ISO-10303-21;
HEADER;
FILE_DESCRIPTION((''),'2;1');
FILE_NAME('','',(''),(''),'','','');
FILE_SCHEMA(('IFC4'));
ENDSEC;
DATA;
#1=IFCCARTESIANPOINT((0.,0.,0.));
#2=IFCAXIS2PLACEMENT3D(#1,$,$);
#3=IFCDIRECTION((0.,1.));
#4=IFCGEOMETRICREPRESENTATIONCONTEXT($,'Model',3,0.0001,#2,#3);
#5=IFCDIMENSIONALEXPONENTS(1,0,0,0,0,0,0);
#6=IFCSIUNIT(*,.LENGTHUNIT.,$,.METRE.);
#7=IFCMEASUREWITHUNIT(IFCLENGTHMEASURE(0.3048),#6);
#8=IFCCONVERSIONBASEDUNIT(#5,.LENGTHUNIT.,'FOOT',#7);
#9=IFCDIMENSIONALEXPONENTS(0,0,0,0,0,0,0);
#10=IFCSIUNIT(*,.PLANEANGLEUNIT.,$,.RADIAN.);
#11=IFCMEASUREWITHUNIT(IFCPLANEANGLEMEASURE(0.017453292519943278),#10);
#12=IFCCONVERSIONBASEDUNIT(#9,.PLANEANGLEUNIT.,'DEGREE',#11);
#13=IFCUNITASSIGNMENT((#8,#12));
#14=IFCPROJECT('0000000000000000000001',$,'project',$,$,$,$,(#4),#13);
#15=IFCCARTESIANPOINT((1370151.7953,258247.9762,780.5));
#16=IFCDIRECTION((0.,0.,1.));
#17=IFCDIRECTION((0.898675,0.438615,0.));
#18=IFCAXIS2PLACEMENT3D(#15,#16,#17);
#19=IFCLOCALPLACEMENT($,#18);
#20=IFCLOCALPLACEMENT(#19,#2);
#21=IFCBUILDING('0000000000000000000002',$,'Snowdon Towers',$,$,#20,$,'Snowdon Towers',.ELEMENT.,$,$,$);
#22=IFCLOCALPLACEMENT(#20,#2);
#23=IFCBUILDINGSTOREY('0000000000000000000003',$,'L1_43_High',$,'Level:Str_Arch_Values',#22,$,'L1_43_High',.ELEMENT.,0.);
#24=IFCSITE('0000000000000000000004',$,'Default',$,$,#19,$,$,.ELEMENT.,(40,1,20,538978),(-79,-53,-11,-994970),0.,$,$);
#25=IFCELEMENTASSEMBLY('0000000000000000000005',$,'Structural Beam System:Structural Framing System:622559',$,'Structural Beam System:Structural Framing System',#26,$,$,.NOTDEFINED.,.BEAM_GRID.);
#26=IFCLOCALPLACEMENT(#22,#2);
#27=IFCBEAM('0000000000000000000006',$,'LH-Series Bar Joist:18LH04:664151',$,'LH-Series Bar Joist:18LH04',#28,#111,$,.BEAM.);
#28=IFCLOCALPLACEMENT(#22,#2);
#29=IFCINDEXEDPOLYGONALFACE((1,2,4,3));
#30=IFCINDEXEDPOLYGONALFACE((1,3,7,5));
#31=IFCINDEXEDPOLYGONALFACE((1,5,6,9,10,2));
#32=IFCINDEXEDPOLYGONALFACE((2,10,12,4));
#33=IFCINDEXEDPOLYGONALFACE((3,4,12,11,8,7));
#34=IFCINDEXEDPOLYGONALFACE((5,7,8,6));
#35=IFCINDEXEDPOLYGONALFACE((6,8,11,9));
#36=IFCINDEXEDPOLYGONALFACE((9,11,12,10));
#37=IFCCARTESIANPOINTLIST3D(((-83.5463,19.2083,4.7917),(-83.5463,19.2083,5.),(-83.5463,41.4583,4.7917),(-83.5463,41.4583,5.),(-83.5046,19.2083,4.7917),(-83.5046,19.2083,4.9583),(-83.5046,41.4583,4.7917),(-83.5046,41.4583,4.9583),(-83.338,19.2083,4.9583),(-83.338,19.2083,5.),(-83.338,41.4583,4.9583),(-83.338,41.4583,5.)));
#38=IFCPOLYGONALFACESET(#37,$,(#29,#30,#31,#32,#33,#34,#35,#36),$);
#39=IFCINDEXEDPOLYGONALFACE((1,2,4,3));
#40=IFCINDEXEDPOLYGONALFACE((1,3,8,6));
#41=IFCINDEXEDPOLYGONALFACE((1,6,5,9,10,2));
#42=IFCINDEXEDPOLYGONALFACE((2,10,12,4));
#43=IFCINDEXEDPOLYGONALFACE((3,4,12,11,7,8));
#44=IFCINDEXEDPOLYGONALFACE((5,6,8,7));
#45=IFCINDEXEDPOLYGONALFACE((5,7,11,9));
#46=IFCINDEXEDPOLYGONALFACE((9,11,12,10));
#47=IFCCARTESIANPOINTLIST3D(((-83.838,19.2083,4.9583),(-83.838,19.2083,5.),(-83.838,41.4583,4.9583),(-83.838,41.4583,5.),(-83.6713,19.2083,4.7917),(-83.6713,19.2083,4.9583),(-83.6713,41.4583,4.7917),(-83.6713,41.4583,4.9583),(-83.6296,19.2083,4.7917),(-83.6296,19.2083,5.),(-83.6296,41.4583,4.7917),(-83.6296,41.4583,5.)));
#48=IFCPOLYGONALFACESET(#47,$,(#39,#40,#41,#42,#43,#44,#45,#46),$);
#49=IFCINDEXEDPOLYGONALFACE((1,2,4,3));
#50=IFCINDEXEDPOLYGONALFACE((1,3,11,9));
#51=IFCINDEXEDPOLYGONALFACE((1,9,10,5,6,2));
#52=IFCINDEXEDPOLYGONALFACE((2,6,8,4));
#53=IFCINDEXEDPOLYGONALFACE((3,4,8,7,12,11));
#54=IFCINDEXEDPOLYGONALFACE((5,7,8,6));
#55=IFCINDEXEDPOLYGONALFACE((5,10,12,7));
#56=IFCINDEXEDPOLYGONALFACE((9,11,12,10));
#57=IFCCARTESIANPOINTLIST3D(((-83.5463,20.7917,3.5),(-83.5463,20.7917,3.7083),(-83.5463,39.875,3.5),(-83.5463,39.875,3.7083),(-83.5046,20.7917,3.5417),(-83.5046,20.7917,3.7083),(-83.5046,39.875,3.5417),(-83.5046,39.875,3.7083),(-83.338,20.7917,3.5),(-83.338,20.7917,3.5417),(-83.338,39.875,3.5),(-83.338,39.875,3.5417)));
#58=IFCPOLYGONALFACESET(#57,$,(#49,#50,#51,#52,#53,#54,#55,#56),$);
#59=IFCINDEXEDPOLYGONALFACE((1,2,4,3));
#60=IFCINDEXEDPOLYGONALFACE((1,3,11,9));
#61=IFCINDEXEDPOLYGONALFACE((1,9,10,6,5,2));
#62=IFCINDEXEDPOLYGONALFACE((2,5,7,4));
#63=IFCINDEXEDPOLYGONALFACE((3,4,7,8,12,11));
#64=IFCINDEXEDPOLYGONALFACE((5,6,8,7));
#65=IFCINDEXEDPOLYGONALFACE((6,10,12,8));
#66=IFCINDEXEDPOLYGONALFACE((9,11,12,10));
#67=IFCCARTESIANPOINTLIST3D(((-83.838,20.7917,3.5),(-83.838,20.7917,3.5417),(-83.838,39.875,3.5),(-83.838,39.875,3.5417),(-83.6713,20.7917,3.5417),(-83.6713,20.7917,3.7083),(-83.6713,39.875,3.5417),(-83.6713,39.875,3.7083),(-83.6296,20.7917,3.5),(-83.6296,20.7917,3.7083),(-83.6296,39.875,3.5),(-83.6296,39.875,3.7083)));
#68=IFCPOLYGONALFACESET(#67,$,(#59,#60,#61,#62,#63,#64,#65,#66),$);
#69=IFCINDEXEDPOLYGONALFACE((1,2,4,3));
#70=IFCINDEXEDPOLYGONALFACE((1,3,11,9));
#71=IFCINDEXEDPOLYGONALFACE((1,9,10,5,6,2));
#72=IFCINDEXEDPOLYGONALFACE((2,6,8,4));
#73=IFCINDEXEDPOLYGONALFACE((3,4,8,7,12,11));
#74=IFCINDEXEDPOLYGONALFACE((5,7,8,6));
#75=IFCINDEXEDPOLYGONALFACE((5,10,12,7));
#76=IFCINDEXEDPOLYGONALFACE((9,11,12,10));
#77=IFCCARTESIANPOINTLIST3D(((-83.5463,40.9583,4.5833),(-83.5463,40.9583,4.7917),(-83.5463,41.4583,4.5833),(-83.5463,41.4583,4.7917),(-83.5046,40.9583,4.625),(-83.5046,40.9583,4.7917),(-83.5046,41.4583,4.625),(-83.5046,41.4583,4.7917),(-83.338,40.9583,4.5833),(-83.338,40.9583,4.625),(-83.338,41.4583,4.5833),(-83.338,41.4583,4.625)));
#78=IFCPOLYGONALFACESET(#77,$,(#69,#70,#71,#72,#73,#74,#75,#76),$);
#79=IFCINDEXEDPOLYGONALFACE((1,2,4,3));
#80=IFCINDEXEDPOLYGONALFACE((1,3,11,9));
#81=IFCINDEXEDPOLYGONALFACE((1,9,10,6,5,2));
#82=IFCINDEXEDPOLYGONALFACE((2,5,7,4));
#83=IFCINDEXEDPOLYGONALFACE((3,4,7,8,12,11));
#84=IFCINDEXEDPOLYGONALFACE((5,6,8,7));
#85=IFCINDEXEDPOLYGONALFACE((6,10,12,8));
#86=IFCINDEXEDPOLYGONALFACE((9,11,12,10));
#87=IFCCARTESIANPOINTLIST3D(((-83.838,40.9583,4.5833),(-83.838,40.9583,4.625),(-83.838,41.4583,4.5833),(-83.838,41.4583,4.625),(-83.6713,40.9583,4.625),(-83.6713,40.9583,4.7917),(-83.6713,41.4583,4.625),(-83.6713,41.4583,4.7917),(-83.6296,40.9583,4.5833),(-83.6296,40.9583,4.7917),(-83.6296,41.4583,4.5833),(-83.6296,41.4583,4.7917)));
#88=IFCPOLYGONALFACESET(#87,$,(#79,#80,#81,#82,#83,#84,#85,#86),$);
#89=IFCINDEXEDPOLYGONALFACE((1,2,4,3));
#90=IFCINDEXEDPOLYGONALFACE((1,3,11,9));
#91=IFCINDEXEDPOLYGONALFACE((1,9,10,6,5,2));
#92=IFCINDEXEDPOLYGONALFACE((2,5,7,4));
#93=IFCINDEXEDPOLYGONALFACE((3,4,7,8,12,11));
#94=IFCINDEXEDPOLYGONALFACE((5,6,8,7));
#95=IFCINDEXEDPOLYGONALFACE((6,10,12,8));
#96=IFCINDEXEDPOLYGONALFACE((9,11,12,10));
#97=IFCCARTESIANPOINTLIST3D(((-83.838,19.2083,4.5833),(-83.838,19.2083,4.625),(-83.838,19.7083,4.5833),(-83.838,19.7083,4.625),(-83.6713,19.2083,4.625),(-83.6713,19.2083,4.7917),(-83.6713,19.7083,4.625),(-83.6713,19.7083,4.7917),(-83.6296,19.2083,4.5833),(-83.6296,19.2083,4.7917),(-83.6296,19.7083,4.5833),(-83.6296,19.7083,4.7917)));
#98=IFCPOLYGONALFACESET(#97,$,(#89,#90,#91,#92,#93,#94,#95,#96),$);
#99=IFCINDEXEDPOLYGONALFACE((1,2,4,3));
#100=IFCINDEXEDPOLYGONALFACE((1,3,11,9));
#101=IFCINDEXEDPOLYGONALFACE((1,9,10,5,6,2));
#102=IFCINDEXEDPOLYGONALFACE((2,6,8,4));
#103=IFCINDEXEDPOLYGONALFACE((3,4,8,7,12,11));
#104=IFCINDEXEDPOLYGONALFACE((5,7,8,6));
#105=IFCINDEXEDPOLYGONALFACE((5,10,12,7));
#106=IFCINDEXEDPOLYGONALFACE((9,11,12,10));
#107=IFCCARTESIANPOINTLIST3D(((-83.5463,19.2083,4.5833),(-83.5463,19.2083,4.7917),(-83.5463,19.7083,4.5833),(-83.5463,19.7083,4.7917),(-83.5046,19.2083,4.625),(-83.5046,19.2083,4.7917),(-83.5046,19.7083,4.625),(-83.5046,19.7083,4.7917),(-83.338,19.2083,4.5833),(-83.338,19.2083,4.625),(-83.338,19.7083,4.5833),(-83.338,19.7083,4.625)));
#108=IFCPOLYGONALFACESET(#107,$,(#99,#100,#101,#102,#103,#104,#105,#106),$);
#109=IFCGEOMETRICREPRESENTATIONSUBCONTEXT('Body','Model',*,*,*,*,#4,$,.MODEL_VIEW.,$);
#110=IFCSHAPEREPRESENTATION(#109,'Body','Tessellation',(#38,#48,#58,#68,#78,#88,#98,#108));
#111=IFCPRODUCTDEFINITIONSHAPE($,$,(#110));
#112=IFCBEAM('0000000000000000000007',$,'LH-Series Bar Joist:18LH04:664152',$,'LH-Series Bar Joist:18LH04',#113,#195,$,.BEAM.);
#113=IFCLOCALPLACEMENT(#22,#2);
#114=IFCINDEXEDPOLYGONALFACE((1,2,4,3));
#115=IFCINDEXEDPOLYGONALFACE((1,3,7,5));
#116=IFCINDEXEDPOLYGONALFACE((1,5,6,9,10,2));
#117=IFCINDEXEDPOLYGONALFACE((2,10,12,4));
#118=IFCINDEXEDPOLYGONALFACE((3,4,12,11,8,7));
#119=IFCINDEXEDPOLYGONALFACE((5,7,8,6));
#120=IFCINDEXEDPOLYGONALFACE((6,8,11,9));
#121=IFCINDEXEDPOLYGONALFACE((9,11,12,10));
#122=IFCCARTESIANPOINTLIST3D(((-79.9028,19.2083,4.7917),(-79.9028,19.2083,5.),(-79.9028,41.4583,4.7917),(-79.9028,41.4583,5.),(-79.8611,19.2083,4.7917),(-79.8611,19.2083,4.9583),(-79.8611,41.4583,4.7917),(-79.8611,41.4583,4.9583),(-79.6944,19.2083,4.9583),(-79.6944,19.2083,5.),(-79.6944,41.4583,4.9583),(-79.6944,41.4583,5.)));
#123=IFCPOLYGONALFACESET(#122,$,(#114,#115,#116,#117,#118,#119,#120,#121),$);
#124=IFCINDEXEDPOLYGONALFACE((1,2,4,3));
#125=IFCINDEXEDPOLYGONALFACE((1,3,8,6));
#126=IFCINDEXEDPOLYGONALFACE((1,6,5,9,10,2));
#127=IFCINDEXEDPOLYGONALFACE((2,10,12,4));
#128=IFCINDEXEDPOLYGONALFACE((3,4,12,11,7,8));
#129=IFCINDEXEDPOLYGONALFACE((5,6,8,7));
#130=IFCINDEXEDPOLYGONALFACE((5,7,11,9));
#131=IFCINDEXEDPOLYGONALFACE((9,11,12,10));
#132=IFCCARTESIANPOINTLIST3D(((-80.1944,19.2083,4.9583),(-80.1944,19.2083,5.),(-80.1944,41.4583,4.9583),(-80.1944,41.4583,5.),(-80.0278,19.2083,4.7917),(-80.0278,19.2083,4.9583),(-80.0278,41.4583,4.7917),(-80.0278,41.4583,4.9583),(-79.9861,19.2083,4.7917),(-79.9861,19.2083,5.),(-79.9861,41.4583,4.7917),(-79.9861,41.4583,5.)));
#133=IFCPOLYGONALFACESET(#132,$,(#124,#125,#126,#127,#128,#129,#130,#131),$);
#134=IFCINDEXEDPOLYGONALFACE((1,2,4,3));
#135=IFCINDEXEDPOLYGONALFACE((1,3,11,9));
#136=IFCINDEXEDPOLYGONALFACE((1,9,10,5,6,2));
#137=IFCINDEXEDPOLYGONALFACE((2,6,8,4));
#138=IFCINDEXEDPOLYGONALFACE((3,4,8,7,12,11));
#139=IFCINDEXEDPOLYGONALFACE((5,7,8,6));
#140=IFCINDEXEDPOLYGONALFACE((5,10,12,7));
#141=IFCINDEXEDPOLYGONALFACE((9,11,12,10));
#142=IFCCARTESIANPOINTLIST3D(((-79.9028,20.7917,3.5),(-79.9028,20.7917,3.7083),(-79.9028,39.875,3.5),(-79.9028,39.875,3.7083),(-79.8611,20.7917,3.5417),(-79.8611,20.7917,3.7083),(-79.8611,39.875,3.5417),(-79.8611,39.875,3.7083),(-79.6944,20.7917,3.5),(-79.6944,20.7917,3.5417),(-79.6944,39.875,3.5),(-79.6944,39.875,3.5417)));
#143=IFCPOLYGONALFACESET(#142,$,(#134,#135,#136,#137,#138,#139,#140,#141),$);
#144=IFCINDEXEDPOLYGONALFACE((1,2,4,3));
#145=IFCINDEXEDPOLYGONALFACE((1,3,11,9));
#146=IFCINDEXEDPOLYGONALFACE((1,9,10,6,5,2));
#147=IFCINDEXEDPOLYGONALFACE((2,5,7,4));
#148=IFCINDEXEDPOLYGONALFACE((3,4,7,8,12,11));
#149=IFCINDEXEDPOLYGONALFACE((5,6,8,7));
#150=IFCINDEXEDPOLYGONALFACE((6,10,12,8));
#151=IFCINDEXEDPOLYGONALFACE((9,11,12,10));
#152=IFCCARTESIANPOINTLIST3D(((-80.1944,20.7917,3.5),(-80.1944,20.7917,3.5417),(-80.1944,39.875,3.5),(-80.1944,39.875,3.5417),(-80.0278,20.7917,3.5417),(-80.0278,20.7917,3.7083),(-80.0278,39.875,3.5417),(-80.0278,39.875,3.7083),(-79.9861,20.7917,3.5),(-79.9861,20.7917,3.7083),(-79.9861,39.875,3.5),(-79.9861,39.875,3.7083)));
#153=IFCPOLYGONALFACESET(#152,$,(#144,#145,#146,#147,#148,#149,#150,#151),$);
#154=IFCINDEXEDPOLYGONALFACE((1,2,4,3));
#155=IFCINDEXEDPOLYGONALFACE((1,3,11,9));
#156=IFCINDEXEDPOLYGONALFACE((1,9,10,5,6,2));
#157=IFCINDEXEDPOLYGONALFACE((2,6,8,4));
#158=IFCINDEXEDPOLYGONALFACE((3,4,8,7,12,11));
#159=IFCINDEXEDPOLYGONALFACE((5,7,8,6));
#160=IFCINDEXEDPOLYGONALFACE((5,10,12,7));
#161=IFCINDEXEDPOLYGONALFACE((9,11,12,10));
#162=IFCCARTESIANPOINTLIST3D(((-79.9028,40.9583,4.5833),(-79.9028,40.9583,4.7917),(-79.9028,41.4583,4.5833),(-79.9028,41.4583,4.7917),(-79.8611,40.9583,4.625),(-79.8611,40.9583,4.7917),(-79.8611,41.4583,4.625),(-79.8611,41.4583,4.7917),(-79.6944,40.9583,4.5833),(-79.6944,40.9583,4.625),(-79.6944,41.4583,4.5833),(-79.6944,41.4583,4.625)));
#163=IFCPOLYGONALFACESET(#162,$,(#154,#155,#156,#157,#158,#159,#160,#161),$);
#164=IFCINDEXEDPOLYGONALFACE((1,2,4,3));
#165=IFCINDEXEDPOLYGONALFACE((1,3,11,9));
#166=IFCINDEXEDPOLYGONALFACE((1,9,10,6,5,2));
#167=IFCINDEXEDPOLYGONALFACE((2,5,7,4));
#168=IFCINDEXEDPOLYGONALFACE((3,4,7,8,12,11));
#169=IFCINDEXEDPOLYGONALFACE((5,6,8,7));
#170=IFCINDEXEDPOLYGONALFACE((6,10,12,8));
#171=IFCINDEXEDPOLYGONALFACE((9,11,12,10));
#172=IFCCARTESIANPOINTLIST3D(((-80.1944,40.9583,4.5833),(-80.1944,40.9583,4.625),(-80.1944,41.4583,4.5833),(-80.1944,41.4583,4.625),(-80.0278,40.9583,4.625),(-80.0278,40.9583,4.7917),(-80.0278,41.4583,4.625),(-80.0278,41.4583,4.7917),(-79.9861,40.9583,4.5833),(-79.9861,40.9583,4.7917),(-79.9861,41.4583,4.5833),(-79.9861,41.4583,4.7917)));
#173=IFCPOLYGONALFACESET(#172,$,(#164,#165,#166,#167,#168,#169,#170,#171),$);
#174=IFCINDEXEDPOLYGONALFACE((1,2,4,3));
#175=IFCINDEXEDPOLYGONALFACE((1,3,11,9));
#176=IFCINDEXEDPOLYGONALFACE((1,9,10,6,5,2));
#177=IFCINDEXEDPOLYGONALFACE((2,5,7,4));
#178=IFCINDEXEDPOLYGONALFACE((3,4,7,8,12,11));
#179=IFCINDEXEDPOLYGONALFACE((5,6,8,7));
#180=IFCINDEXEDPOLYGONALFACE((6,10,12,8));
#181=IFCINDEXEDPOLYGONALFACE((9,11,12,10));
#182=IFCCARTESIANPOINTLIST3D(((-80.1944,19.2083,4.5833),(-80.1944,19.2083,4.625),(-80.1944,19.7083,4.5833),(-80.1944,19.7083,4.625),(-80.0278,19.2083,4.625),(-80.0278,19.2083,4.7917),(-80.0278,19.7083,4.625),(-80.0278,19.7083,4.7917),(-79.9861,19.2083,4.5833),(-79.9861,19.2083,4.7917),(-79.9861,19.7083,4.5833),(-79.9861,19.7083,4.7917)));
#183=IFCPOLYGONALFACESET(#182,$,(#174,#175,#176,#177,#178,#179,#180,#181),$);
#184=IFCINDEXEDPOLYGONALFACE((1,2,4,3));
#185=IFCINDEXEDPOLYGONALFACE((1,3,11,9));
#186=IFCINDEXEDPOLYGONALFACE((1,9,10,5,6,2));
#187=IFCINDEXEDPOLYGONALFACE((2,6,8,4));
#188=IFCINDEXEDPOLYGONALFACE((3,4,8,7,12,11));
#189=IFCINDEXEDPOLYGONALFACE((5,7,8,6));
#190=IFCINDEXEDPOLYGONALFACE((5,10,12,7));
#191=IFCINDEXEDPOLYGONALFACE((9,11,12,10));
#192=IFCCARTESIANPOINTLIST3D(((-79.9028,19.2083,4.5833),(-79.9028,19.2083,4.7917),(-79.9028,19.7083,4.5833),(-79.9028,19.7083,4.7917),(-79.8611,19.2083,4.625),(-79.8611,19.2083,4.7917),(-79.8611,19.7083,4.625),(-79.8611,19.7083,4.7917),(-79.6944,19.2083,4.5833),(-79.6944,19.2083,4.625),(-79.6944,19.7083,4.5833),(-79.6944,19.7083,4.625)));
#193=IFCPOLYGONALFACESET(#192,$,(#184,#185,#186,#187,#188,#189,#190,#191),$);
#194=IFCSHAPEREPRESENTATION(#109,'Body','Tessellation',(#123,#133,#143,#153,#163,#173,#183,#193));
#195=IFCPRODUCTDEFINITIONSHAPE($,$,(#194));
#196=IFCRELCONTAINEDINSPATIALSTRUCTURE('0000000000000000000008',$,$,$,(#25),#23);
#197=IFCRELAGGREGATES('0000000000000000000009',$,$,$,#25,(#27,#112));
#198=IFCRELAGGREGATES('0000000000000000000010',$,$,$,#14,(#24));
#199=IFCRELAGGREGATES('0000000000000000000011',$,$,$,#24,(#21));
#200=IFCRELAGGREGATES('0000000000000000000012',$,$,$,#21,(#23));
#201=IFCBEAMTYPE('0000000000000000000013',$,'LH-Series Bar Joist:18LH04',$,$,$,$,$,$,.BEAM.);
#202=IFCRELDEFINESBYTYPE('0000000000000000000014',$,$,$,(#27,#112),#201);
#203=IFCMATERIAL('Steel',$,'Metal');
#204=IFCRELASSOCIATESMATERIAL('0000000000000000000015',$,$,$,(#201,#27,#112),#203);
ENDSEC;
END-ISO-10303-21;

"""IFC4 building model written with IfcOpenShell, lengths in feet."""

from ifc_helpers import new_model, entity, si_unit, converted_unit, direction, frame, origin, place, context, subcontext, project, spatial, indexed_curve, outline, extrude, source, transform, mapped, material, type_object, type_shapes, element, aggregate, save


model = new_model("IFC4")

# Units and contexts
model_context = context("Model", 3, precision=0.0001, world=origin(), true_north=direction((0.0, 1.0)))
body_context = subcontext(model_context, "Body", "Model", "MODEL_VIEW")
ifc_project = project(units=[converted_unit("LENGTHUNIT", "FOOT", entity("IfcLengthMeasure", 0.3048), si_unit("LENGTHUNIT", "METRE"), dimensions=[1, 0, 0, 0, 0, 0, 0]), converted_unit("PLANEANGLEUNIT", "DEGREE", entity("IfcPlaneAngleMeasure", 0.017453292519943278), si_unit("PLANEANGLEUNIT", "RADIAN"), dimensions=[0, 0, 0, 0, 0, 0, 0])], contexts=[model_context])

# Site, building, storey
site_placement = place(None, frame((1370151.7953, 258247.9762, 780.5), z_axis=(0.0, 0.0, 1.0), x_axis=(0.898675, 0.438615, 0.0)))
site = spatial("IfcSite", under=ifc_project, at=site_placement, Name="Default", CompositionType="ELEMENT", RefLatitude=(40, 1, 20, 538978), RefLongitude=(-79, -53, -11, -994970), RefElevation=0.0)
building_placement = place(site_placement, origin())
building = spatial("IfcBuilding", under=site, at=building_placement, Name="Snowdon Towers", LongName="Snowdon Towers", CompositionType="ELEMENT")
storey_placement = place(building_placement, origin())
storey = spatial("IfcBuildingStorey", under=building, at=storey_placement, Name="L1_43_High", ObjectType="Level:Str_Arch_Values", LongName="L1_43_High", CompositionType="ELEMENT", Elevation=0.0)

# Shared definitions
ifc_material_1 = material(Name="Steel", Category="Metal")

# Element assembly, beams
assembly_placement = place(storey_placement, origin())
assembly = element("IfcElementAssembly", 1, at=assembly_placement, inside=storey, Name="Structural Beam System:Structural Framing System:622559", ObjectType="Structural Beam System:Structural Framing System", AssemblyPlace="NOTDEFINED", PredefinedType="BEAM_GRID")
beam_type_1 = type_object("IfcBeamType", Name="LH-Series Bar Joist:18LH04", PredefinedType="BEAM", material=ifc_material_1)
shared_shape_1 = source(origin(), body_context, "Body", "SweptSolid", [
    extrude(outline(indexed_curve([(-0.0833, -0.0833), (0.125, -0.0833), (0.125, -0.0417), (-0.0417, -0.0417), (-0.0417, 0.125), (-0.0833, 0.125), (-0.0833, -0.0833)], self_intersect=False)), frame((-11.125, -0.125, 0.6667), z_axis=(1.0, 0.0, 0.0), x_axis=(0.0, -1.0, 0.0)), (0.0, 0.0, 1.0), 22.25),
    extrude(outline(indexed_curve([(-0.0833, -0.0833), (0.125, -0.0833), (0.125, -0.0417), (-0.0417, -0.0417), (-0.0417, 0.125), (-0.0833, 0.125), (-0.0833, -0.0833)], self_intersect=False)), frame((-11.125, 0.125, 0.6667), z_axis=(1.0, 0.0, 0.0), x_axis=(0.0, 0.0, -1.0)), (0.0, 0.0, 1.0), 22.25),
    extrude(outline(indexed_curve([(-0.0833, -0.0833), (0.125, -0.0833), (0.125, -0.0417), (-0.0417, -0.0417), (-0.0417, 0.125), (-0.0833, 0.125), (-0.0833, -0.0833)], self_intersect=False)), frame((-9.5417, -0.125, -0.6667), z_axis=(1.0, 0.0, 0.0), x_axis=(0.0, 0.0, 1.0)), (0.0, 0.0, 1.0), 19.0833),
    extrude(outline(indexed_curve([(-0.0833, -0.0833), (0.125, -0.0833), (0.125, -0.0417), (-0.0417, -0.0417), (-0.0417, 0.125), (-0.0833, 0.125), (-0.0833, -0.0833)], self_intersect=False)), frame((-9.5417, 0.125, -0.6667), z_axis=(1.0, 0.0, 0.0), x_axis=(0.0, 1.0, 0.0)), (0.0, 0.0, 1.0), 19.0833),
    extrude(outline(indexed_curve([(-0.0833, -0.0833), (0.125, -0.0833), (0.125, -0.0417), (-0.0417, -0.0417), (-0.0417, 0.125), (-0.0833, 0.125), (-0.0833, -0.0833)], self_intersect=False)), frame((10.625, -0.125, 0.4167), z_axis=(1.0, 0.0, 0.0), x_axis=(0.0, 0.0, 1.0)), (0.0, 0.0, 1.0), 0.5),
    extrude(outline(indexed_curve([(-0.0833, -0.0833), (0.125, -0.0833), (0.125, -0.0417), (-0.0417, -0.0417), (-0.0417, 0.125), (-0.0833, 0.125), (-0.0833, -0.0833)], self_intersect=False)), frame((10.625, 0.125, 0.4167), z_axis=(1.0, 0.0, 0.0), x_axis=(0.0, 1.0, 0.0)), (0.0, 0.0, 1.0), 0.5),
    extrude(outline(indexed_curve([(-0.0833, -0.125), (-0.0417, -0.125), (-0.0417, 0.0417), (0.125, 0.0417), (0.125, 0.0833), (-0.0833, 0.0833), (-0.0833, -0.125)], self_intersect=False)), frame((-11.125, 0.125, 0.4167), z_axis=(1.0, 0.0, 0.0), x_axis=(0.0, 0.0, 1.0)), (0.0, 0.0, 1.0), 0.5),
    extrude(outline(indexed_curve([(-0.0833, -0.0833), (0.125, -0.0833), (0.125, -0.0417), (-0.0417, -0.0417), (-0.0417, 0.125), (-0.0833, 0.125), (-0.0833, -0.0833)], self_intersect=False)), frame((-11.125, -0.125, 0.4167), z_axis=(1.0, 0.0, 0.0), x_axis=(0.0, 0.0, 1.0)), (0.0, 0.0, 1.0), 0.5),
])
type_shapes(beam_type_1, [shared_shape_1])
beam_1_placement = place(assembly_placement, frame((-83.588, 30.3333, 4.25), z_axis=(0.0, 0.0, 1.0), x_axis=(0.0, 1.0, 0.0)))
beam_1 = element("IfcBeam", 2, at=beam_1_placement, type_object=beam_type_1, material=ifc_material_1, Name="LH-Series Bar Joist:18LH04:664151", ObjectType="LH-Series Bar Joist:18LH04", PredefinedType="BEAM", context=body_context, shape_type="MappedRepresentation", body=[
    mapped(shared_shape_1, transform((0.0, 0.0, 0.0), scale=1.0)),
])
beam_2_placement = place(assembly_placement, frame((-79.9444, 30.3333, 4.25), z_axis=(0.0, 0.0, 1.0), x_axis=(0.0, 1.0, 0.0)))
beam_2 = element("IfcBeam", 3, at=beam_2_placement, type_object=beam_type_1, material=ifc_material_1, Name="LH-Series Bar Joist:18LH04:664152", ObjectType="LH-Series Bar Joist:18LH04", PredefinedType="BEAM", context=body_context, shape_type="MappedRepresentation", body=[
    mapped(shared_shape_1, transform((0.0, 0.0, 0.0), scale=1.0)),
])
aggregate(assembly, [beam_1, beam_2])

save(model, "model.ifc")
